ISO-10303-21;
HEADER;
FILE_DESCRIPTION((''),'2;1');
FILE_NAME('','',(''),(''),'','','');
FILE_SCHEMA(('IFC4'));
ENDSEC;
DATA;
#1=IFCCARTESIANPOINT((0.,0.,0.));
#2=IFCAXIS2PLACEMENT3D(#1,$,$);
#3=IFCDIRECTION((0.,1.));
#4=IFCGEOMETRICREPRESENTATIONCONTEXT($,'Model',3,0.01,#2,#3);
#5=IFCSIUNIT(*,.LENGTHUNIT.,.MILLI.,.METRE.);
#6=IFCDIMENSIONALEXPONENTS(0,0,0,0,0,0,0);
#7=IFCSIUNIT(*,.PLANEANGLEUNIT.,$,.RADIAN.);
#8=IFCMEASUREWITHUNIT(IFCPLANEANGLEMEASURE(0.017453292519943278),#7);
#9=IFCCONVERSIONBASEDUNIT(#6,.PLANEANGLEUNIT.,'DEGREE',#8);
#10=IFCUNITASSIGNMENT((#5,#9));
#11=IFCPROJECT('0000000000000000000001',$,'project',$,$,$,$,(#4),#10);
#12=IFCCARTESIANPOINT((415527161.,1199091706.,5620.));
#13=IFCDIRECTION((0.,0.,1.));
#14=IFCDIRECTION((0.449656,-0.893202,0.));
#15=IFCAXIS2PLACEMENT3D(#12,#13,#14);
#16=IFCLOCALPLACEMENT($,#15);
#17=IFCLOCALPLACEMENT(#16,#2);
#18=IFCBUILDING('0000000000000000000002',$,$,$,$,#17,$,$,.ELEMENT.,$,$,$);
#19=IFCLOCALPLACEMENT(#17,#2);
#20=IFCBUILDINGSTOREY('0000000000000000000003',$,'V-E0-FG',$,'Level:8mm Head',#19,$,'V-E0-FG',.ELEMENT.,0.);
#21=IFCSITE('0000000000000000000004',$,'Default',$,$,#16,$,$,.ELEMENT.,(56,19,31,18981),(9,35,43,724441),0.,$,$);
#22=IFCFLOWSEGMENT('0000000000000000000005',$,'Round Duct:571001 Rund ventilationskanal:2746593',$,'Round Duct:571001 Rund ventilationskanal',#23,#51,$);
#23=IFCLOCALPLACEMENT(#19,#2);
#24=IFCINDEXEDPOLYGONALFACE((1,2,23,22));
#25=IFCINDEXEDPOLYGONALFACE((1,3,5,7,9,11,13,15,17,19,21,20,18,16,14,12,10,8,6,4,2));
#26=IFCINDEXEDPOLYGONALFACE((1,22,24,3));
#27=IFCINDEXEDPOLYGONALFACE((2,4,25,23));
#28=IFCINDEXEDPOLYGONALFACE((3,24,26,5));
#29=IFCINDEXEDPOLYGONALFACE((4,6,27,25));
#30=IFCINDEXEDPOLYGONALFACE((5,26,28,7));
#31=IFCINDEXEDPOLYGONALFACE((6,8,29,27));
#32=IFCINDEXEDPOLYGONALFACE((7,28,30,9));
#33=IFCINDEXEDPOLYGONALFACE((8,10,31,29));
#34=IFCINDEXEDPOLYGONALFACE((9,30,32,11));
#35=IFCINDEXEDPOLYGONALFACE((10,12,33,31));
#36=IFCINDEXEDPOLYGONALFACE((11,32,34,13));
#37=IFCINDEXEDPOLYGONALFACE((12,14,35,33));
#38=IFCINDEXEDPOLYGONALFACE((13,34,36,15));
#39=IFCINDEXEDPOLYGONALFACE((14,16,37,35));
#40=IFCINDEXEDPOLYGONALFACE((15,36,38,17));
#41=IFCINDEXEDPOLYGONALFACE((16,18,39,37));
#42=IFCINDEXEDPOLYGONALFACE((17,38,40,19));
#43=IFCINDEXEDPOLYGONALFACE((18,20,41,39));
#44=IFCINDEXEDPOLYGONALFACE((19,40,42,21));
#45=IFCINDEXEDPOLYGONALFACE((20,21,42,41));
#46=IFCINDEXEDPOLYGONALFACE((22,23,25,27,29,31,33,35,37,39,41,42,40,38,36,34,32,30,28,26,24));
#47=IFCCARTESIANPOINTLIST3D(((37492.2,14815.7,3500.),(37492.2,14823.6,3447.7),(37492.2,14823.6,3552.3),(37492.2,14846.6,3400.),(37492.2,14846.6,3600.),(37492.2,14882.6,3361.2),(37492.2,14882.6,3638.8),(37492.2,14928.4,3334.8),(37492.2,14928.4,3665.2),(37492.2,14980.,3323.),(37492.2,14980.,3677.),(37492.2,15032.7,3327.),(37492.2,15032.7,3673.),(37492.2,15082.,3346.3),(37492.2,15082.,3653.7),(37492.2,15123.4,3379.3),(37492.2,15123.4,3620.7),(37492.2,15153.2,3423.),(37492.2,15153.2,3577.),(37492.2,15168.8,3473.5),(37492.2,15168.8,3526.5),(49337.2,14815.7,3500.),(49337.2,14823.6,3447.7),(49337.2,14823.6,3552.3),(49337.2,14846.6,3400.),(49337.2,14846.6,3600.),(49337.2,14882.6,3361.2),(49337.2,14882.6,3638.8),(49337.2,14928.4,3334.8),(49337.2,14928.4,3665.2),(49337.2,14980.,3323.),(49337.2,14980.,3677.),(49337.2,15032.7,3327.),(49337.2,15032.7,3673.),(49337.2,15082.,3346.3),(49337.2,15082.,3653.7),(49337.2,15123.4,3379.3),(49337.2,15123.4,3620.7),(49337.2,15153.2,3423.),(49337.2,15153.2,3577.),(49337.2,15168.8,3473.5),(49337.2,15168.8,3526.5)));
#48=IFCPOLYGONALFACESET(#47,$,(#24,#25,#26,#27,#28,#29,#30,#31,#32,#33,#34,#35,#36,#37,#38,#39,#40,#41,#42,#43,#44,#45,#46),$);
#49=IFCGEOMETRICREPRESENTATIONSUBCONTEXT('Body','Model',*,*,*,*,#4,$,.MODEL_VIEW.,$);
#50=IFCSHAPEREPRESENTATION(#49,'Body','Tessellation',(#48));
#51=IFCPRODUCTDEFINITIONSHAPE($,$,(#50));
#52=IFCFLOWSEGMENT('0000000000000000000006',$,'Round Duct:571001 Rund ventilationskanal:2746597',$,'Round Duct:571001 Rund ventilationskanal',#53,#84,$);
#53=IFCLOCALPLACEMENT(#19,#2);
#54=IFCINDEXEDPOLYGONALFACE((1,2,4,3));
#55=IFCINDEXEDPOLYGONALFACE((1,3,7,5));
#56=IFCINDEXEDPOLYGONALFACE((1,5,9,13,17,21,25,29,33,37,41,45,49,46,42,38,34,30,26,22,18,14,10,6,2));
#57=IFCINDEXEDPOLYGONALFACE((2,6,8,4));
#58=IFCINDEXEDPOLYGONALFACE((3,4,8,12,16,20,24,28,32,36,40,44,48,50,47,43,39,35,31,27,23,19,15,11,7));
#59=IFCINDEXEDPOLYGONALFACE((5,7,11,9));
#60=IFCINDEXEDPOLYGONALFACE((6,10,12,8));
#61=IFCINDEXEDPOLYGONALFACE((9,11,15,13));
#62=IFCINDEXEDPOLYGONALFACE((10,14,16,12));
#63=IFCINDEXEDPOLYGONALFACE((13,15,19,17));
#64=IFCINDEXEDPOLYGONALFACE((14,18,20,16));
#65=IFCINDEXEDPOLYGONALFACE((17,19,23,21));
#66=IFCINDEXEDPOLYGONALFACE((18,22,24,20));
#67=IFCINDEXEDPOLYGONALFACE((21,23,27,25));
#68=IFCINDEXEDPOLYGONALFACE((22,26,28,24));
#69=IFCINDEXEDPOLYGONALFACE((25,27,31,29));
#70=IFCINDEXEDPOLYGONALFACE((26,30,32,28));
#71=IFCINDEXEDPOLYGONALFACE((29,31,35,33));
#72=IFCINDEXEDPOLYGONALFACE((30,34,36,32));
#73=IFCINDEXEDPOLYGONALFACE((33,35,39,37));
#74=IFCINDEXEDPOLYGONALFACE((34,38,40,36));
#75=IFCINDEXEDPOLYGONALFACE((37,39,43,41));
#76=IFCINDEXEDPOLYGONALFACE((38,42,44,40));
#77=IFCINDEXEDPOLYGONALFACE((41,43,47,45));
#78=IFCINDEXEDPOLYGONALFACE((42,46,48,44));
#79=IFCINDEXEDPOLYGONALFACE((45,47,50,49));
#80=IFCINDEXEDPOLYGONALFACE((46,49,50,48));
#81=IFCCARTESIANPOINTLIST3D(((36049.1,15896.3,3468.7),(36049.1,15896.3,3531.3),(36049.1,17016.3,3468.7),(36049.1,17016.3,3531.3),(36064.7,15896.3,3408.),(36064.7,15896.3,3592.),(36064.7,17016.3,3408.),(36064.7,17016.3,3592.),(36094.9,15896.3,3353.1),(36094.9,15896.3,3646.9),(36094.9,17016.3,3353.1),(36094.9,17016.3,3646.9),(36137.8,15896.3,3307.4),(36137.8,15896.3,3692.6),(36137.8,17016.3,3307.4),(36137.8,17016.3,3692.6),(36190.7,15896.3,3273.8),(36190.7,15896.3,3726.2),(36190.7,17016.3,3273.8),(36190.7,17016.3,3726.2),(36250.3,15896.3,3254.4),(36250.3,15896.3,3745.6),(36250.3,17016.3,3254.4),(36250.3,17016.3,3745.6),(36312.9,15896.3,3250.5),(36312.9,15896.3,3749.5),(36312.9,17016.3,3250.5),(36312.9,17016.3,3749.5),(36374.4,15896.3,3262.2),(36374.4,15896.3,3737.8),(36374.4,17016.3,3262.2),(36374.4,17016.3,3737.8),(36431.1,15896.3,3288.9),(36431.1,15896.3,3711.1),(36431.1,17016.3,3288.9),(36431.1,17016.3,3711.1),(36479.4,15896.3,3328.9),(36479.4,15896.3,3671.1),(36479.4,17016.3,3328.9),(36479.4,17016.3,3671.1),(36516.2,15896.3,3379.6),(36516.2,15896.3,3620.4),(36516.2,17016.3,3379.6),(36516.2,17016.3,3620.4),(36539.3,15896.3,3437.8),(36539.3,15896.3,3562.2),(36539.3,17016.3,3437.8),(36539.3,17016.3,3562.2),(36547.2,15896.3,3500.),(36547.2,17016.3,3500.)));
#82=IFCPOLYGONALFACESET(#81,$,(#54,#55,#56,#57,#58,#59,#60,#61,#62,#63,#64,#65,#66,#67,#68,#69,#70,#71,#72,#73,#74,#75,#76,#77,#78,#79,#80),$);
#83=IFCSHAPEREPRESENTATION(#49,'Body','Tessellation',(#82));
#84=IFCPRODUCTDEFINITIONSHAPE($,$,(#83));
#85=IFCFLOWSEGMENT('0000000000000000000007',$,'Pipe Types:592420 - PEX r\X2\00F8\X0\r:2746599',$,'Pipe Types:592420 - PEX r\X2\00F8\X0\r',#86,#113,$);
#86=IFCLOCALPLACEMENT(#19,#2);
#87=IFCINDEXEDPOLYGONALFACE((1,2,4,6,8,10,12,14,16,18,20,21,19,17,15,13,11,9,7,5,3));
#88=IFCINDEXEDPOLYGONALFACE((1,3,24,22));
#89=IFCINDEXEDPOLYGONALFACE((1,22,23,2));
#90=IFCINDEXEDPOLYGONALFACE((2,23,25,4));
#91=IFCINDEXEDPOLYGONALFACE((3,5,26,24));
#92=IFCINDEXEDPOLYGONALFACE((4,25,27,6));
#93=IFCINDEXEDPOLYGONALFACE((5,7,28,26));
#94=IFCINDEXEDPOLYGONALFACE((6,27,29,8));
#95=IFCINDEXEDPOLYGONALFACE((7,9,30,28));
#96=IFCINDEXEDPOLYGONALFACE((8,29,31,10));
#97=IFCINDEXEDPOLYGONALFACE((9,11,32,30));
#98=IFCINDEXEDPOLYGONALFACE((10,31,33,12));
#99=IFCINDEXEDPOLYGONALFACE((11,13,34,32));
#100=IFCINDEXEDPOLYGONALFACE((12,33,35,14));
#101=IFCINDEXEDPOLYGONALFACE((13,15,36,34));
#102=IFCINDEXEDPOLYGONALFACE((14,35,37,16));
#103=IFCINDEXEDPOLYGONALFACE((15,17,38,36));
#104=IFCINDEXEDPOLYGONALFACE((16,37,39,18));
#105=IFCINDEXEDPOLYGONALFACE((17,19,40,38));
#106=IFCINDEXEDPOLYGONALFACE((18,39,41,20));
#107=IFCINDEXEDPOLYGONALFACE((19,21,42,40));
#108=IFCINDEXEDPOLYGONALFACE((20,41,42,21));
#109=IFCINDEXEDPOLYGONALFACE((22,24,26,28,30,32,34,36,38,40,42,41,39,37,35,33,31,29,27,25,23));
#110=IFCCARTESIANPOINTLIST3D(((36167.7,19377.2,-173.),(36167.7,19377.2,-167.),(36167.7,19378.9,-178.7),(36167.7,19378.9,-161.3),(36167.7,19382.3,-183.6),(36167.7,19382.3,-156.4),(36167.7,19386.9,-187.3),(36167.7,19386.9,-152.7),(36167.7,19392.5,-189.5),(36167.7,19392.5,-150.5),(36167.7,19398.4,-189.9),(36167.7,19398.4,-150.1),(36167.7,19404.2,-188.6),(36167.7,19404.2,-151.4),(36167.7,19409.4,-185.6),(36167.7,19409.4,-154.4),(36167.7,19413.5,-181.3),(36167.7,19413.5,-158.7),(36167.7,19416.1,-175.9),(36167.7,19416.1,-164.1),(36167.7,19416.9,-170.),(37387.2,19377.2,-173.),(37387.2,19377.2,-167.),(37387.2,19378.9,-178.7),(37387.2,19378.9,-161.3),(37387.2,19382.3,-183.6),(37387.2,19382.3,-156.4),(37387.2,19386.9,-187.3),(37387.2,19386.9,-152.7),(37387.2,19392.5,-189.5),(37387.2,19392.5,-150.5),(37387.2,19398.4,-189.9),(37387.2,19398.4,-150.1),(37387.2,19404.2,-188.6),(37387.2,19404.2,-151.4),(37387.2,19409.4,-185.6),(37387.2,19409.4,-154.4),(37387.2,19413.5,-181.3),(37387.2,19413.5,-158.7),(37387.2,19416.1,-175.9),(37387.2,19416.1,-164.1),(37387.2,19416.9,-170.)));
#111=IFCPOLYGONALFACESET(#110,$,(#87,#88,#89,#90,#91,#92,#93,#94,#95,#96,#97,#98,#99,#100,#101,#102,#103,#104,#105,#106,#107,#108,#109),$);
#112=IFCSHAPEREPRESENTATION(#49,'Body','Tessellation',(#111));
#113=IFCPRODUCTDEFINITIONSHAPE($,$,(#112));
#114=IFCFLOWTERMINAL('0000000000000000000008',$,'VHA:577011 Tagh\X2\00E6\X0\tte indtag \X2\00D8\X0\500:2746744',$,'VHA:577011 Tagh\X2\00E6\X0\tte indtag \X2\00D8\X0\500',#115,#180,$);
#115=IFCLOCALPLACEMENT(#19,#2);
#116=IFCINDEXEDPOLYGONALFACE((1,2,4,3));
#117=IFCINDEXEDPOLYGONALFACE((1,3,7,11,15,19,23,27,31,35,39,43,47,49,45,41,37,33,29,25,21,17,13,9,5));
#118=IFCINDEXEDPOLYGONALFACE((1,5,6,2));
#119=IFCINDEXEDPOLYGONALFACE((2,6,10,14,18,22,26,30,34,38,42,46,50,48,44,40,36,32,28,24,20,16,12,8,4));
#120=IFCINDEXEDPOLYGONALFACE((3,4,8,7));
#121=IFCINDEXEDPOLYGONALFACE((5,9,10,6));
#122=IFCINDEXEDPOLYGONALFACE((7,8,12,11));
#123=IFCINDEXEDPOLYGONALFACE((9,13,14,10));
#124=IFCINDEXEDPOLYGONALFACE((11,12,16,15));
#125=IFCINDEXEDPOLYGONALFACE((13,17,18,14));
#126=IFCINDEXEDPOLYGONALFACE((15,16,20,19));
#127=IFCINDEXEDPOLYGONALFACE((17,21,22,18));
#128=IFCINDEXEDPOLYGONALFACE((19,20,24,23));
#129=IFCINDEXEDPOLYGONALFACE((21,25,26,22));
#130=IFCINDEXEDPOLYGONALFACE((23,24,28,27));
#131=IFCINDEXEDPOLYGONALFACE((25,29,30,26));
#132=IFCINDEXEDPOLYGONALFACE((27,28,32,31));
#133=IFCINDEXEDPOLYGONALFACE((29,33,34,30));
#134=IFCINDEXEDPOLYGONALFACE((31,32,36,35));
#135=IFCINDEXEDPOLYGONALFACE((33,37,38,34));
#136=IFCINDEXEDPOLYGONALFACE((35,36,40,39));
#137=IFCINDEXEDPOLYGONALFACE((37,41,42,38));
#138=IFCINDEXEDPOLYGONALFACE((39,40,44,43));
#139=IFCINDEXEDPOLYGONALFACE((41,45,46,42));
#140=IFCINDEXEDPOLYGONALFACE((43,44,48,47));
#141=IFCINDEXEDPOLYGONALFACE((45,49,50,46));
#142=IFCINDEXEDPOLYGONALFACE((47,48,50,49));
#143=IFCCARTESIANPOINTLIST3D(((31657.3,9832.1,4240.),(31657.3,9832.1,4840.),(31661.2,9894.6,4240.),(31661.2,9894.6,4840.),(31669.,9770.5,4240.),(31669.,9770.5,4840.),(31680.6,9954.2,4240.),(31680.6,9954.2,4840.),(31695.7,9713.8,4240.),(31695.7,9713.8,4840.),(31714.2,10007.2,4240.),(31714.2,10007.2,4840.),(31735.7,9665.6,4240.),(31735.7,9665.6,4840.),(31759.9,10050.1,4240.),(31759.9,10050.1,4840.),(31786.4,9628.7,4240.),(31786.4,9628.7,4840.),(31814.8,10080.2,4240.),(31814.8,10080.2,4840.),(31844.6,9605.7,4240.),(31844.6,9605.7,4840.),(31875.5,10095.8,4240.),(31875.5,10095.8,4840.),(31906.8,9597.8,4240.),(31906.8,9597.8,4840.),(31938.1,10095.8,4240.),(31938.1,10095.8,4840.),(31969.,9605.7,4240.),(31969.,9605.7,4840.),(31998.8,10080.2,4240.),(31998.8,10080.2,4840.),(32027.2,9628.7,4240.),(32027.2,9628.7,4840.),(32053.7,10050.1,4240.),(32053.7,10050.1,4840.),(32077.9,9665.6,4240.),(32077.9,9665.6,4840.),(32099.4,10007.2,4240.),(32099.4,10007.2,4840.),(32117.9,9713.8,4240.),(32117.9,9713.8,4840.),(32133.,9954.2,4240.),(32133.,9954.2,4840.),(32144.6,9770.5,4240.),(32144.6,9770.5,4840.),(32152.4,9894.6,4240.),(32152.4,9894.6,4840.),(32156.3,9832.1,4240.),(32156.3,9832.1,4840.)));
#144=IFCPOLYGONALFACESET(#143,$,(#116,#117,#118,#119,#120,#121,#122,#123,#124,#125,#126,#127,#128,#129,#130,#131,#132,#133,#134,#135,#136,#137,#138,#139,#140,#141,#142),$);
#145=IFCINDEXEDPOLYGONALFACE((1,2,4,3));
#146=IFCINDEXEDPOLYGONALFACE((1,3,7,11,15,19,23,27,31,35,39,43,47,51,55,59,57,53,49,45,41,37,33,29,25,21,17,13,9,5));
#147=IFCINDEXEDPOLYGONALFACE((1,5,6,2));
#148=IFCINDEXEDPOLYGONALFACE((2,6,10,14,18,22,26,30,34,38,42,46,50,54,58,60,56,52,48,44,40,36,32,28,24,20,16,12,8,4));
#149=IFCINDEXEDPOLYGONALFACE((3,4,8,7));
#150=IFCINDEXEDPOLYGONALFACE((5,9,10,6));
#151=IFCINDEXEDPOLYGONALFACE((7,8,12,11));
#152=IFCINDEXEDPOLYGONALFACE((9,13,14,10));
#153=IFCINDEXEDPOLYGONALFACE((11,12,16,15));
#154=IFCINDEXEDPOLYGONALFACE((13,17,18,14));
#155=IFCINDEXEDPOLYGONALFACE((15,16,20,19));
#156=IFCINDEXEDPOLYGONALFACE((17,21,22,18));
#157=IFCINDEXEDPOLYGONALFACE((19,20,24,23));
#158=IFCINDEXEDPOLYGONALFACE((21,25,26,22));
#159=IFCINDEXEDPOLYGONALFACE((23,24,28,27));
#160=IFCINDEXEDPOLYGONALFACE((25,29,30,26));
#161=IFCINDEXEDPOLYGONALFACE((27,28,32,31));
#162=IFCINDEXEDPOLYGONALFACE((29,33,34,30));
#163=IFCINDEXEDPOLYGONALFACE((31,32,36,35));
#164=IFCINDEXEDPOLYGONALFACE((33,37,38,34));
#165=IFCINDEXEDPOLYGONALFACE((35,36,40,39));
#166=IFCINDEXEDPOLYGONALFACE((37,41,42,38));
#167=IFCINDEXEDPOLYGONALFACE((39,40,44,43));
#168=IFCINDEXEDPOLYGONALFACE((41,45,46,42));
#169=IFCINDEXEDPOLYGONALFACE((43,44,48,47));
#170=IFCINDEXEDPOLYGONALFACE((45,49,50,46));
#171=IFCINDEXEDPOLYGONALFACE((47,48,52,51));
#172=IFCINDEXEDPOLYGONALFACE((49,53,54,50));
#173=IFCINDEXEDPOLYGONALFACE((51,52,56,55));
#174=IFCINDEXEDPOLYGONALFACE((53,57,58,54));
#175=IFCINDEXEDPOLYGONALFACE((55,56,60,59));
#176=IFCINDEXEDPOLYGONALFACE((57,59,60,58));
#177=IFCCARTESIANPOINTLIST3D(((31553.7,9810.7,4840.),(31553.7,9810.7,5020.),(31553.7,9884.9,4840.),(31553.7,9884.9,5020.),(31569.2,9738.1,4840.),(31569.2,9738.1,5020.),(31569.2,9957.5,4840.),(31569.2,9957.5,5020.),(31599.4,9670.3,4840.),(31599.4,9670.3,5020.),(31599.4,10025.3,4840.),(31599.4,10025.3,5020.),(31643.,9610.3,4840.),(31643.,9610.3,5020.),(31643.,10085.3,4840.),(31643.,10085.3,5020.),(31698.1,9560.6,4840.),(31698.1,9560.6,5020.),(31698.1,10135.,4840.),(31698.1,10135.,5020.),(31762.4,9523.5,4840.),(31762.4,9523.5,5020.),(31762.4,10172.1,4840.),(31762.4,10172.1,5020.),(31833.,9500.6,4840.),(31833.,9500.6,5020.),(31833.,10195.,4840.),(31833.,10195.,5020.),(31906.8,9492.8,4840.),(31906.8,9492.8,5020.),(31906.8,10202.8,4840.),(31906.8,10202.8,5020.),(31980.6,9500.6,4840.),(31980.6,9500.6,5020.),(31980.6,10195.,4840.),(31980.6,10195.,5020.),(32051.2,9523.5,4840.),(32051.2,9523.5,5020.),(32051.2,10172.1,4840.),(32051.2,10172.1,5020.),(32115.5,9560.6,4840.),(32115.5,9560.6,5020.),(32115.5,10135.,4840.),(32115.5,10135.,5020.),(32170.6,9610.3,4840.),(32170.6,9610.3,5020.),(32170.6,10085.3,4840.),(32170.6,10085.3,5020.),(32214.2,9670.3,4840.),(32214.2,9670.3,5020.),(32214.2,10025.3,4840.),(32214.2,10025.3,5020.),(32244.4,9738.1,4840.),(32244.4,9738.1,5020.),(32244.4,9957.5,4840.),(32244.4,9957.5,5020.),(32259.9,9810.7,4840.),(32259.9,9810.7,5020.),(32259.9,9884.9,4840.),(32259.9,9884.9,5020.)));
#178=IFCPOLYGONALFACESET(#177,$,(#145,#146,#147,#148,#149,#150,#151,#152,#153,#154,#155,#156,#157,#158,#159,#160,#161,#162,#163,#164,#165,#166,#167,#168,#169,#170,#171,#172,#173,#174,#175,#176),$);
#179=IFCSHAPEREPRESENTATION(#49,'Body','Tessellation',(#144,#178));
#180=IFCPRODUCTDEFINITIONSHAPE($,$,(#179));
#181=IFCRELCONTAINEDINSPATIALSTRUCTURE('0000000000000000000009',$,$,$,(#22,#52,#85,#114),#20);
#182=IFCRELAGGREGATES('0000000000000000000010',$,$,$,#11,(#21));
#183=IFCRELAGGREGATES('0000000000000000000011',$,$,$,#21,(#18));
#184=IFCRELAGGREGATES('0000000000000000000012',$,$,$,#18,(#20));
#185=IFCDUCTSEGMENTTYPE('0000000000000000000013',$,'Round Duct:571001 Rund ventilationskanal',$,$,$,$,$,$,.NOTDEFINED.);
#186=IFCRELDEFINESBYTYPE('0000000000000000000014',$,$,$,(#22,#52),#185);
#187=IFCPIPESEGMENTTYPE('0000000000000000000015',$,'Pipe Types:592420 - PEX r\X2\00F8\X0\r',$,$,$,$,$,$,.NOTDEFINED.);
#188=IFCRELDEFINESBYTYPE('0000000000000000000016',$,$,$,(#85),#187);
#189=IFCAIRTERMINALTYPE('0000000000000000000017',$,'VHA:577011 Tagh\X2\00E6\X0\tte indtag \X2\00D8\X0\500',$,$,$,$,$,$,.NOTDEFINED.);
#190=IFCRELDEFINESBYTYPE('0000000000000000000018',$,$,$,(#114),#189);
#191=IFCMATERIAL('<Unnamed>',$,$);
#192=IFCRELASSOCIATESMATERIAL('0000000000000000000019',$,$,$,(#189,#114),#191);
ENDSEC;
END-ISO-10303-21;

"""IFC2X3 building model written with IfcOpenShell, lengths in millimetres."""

from ifc_helpers import new_model, entity, si_unit, converted_unit, direction, frame, frame_2d, origin, place, context, subcontext, project, spatial, circle, extrude, source, transform, mapped, material, type_object, type_shapes, element, save


model = new_model("IFC2X3")

# Units and contexts
model_context = context("Model", 3, precision=0.01, world=origin(), true_north=direction((0.0, 1.0)))
body_context = subcontext(model_context, "Body", "Model", "MODEL_VIEW")
ifc_project = project(units=[si_unit("LENGTHUNIT", "METRE", prefix="MILLI"), converted_unit("PLANEANGLEUNIT", "DEGREE", entity("IfcPlaneAngleMeasure", 0.017453292519943278), si_unit("PLANEANGLEUNIT", "RADIAN"), dimensions=[0, 0, 0, 0, 0, 0, 0])], contexts=[model_context])

# Site, building, storey
site_placement = place(None, frame((415527161.0, 1199091706.0, 5620.0), z_axis=(0.0, 0.0, 1.0), x_axis=(0.449656, -0.893202, 0.0)))
site = spatial("IfcSite", under=ifc_project, at=site_placement, Name="Default", CompositionType="ELEMENT", RefLatitude=(56, 19, 31, 18981), RefLongitude=(9, 35, 43, 724441), RefElevation=0.0)
building_placement = place(site_placement, origin())
building = spatial("IfcBuilding", under=site, at=building_placement, CompositionType="ELEMENT")
storey_placement = place(building_placement, origin())
storey = spatial("IfcBuildingStorey", under=building, at=storey_placement, Name="V-E0-FG", ObjectType="Level:8mm Head", LongName="V-E0-FG", CompositionType="ELEMENT", Elevation=0.0)

# Flow segments
duct_segment_type = type_object("IfcDuctSegmentType", Name="Round Duct:571001 Rund ventilationskanal", PredefinedType="NOTDEFINED")
flow_segment_1_placement = place(storey_placement, origin())
element("IfcFlowSegment", 1, at=flow_segment_1_placement, inside=storey, type_object=duct_segment_type, Name="Round Duct:571001 Rund ventilationskanal:2746593", ObjectType="Round Duct:571001 Rund ventilationskanal", context=body_context, shape_type="SweptSolid", body=[
    extrude(circle(Radius=177.5, at=frame_2d((0.0, 0.0), x_axis=(1.0, 0.0))), frame((37492.2, 14993.2, 3500.0), z_axis=(1.0, 0.0, 0.0), x_axis=(0.0, -1.0, 0.0)), (0.0, 0.0, 1.0), 11845.0),
])
flow_segment_2_placement = place(storey_placement, origin())
element("IfcFlowSegment", 2, at=flow_segment_2_placement, inside=storey, type_object=duct_segment_type, Name="Round Duct:571001 Rund ventilationskanal:2746597", ObjectType="Round Duct:571001 Rund ventilationskanal", context=body_context, shape_type="SweptSolid", body=[
    extrude(circle(Radius=250.0, at=frame_2d((0.0, 0.0), x_axis=(1.0, 0.0))), frame((36297.2, 15896.3, 3500.0), z_axis=(0.0, 1.0, 0.0), x_axis=(1.0, 0.0, 0.0)), (0.0, 0.0, 1.0), 1120.0),
])
pipe_segment_type = type_object("IfcPipeSegmentType", Name="Pipe Types:592420 - PEX rør", PredefinedType="NOTDEFINED")
flow_segment_3_placement = place(storey_placement, origin())
element("IfcFlowSegment", 3, at=flow_segment_3_placement, inside=storey, type_object=pipe_segment_type, Name="Pipe Types:592420 - PEX rør:2746599", ObjectType="Pipe Types:592420 - PEX rør", context=body_context, shape_type="SweptSolid", body=[
    extrude(circle(Radius=20.0, at=frame_2d((0.0, 0.0), x_axis=(1.0, 0.0))), frame((36167.7, 19396.9, -170.0), z_axis=(1.0, 0.0, 0.0), x_axis=(0.0, 1.0, 0.0)), (0.0, 0.0, 1.0), 1219.5),
])

# Flow terminal
ifc_material = material(Name="<Unnamed>")
air_terminal_type_1 = type_object("IfcAirTerminalType", Name="VHA:577011 Taghætte indtag Ø500", PredefinedType="NOTDEFINED", material=ifc_material)
shared_shape_1 = source(origin(), body_context, "Body", "SweptSolid", [
    extrude(circle(Radius=250.0, at=frame_2d((0.0, 0.0), x_axis=(1.0, 0.0))), origin(), (0.0, 0.0, 1.0), 600.0),
    extrude(circle(Radius=355.0, at=frame_2d((0.0, 0.0), x_axis=(1.0, 0.0))), frame((0.0, 0.0, 600.0)), (0.0, 0.0, 1.0), 180.0),
])
type_shapes(air_terminal_type_1, [shared_shape_1])
flow_terminal_1_placement = place(storey_placement, frame((31906.8, 9847.8, 4240.0), z_axis=(0.0, 0.0, 1.0), x_axis=(0.0, -1.0, 0.0)))
element("IfcFlowTerminal", 4, at=flow_terminal_1_placement, inside=storey, type_object=air_terminal_type_1, material=ifc_material, Name="VHA:577011 Taghætte indtag Ø500:2746744", ObjectType="VHA:577011 Taghætte indtag Ø500", context=body_context, shape_type="MappedRepresentation", body=[
    mapped(shared_shape_1, transform((0.0, 0.0, 0.0), scale=1.0)),
])

save(model, "model.ifc")
